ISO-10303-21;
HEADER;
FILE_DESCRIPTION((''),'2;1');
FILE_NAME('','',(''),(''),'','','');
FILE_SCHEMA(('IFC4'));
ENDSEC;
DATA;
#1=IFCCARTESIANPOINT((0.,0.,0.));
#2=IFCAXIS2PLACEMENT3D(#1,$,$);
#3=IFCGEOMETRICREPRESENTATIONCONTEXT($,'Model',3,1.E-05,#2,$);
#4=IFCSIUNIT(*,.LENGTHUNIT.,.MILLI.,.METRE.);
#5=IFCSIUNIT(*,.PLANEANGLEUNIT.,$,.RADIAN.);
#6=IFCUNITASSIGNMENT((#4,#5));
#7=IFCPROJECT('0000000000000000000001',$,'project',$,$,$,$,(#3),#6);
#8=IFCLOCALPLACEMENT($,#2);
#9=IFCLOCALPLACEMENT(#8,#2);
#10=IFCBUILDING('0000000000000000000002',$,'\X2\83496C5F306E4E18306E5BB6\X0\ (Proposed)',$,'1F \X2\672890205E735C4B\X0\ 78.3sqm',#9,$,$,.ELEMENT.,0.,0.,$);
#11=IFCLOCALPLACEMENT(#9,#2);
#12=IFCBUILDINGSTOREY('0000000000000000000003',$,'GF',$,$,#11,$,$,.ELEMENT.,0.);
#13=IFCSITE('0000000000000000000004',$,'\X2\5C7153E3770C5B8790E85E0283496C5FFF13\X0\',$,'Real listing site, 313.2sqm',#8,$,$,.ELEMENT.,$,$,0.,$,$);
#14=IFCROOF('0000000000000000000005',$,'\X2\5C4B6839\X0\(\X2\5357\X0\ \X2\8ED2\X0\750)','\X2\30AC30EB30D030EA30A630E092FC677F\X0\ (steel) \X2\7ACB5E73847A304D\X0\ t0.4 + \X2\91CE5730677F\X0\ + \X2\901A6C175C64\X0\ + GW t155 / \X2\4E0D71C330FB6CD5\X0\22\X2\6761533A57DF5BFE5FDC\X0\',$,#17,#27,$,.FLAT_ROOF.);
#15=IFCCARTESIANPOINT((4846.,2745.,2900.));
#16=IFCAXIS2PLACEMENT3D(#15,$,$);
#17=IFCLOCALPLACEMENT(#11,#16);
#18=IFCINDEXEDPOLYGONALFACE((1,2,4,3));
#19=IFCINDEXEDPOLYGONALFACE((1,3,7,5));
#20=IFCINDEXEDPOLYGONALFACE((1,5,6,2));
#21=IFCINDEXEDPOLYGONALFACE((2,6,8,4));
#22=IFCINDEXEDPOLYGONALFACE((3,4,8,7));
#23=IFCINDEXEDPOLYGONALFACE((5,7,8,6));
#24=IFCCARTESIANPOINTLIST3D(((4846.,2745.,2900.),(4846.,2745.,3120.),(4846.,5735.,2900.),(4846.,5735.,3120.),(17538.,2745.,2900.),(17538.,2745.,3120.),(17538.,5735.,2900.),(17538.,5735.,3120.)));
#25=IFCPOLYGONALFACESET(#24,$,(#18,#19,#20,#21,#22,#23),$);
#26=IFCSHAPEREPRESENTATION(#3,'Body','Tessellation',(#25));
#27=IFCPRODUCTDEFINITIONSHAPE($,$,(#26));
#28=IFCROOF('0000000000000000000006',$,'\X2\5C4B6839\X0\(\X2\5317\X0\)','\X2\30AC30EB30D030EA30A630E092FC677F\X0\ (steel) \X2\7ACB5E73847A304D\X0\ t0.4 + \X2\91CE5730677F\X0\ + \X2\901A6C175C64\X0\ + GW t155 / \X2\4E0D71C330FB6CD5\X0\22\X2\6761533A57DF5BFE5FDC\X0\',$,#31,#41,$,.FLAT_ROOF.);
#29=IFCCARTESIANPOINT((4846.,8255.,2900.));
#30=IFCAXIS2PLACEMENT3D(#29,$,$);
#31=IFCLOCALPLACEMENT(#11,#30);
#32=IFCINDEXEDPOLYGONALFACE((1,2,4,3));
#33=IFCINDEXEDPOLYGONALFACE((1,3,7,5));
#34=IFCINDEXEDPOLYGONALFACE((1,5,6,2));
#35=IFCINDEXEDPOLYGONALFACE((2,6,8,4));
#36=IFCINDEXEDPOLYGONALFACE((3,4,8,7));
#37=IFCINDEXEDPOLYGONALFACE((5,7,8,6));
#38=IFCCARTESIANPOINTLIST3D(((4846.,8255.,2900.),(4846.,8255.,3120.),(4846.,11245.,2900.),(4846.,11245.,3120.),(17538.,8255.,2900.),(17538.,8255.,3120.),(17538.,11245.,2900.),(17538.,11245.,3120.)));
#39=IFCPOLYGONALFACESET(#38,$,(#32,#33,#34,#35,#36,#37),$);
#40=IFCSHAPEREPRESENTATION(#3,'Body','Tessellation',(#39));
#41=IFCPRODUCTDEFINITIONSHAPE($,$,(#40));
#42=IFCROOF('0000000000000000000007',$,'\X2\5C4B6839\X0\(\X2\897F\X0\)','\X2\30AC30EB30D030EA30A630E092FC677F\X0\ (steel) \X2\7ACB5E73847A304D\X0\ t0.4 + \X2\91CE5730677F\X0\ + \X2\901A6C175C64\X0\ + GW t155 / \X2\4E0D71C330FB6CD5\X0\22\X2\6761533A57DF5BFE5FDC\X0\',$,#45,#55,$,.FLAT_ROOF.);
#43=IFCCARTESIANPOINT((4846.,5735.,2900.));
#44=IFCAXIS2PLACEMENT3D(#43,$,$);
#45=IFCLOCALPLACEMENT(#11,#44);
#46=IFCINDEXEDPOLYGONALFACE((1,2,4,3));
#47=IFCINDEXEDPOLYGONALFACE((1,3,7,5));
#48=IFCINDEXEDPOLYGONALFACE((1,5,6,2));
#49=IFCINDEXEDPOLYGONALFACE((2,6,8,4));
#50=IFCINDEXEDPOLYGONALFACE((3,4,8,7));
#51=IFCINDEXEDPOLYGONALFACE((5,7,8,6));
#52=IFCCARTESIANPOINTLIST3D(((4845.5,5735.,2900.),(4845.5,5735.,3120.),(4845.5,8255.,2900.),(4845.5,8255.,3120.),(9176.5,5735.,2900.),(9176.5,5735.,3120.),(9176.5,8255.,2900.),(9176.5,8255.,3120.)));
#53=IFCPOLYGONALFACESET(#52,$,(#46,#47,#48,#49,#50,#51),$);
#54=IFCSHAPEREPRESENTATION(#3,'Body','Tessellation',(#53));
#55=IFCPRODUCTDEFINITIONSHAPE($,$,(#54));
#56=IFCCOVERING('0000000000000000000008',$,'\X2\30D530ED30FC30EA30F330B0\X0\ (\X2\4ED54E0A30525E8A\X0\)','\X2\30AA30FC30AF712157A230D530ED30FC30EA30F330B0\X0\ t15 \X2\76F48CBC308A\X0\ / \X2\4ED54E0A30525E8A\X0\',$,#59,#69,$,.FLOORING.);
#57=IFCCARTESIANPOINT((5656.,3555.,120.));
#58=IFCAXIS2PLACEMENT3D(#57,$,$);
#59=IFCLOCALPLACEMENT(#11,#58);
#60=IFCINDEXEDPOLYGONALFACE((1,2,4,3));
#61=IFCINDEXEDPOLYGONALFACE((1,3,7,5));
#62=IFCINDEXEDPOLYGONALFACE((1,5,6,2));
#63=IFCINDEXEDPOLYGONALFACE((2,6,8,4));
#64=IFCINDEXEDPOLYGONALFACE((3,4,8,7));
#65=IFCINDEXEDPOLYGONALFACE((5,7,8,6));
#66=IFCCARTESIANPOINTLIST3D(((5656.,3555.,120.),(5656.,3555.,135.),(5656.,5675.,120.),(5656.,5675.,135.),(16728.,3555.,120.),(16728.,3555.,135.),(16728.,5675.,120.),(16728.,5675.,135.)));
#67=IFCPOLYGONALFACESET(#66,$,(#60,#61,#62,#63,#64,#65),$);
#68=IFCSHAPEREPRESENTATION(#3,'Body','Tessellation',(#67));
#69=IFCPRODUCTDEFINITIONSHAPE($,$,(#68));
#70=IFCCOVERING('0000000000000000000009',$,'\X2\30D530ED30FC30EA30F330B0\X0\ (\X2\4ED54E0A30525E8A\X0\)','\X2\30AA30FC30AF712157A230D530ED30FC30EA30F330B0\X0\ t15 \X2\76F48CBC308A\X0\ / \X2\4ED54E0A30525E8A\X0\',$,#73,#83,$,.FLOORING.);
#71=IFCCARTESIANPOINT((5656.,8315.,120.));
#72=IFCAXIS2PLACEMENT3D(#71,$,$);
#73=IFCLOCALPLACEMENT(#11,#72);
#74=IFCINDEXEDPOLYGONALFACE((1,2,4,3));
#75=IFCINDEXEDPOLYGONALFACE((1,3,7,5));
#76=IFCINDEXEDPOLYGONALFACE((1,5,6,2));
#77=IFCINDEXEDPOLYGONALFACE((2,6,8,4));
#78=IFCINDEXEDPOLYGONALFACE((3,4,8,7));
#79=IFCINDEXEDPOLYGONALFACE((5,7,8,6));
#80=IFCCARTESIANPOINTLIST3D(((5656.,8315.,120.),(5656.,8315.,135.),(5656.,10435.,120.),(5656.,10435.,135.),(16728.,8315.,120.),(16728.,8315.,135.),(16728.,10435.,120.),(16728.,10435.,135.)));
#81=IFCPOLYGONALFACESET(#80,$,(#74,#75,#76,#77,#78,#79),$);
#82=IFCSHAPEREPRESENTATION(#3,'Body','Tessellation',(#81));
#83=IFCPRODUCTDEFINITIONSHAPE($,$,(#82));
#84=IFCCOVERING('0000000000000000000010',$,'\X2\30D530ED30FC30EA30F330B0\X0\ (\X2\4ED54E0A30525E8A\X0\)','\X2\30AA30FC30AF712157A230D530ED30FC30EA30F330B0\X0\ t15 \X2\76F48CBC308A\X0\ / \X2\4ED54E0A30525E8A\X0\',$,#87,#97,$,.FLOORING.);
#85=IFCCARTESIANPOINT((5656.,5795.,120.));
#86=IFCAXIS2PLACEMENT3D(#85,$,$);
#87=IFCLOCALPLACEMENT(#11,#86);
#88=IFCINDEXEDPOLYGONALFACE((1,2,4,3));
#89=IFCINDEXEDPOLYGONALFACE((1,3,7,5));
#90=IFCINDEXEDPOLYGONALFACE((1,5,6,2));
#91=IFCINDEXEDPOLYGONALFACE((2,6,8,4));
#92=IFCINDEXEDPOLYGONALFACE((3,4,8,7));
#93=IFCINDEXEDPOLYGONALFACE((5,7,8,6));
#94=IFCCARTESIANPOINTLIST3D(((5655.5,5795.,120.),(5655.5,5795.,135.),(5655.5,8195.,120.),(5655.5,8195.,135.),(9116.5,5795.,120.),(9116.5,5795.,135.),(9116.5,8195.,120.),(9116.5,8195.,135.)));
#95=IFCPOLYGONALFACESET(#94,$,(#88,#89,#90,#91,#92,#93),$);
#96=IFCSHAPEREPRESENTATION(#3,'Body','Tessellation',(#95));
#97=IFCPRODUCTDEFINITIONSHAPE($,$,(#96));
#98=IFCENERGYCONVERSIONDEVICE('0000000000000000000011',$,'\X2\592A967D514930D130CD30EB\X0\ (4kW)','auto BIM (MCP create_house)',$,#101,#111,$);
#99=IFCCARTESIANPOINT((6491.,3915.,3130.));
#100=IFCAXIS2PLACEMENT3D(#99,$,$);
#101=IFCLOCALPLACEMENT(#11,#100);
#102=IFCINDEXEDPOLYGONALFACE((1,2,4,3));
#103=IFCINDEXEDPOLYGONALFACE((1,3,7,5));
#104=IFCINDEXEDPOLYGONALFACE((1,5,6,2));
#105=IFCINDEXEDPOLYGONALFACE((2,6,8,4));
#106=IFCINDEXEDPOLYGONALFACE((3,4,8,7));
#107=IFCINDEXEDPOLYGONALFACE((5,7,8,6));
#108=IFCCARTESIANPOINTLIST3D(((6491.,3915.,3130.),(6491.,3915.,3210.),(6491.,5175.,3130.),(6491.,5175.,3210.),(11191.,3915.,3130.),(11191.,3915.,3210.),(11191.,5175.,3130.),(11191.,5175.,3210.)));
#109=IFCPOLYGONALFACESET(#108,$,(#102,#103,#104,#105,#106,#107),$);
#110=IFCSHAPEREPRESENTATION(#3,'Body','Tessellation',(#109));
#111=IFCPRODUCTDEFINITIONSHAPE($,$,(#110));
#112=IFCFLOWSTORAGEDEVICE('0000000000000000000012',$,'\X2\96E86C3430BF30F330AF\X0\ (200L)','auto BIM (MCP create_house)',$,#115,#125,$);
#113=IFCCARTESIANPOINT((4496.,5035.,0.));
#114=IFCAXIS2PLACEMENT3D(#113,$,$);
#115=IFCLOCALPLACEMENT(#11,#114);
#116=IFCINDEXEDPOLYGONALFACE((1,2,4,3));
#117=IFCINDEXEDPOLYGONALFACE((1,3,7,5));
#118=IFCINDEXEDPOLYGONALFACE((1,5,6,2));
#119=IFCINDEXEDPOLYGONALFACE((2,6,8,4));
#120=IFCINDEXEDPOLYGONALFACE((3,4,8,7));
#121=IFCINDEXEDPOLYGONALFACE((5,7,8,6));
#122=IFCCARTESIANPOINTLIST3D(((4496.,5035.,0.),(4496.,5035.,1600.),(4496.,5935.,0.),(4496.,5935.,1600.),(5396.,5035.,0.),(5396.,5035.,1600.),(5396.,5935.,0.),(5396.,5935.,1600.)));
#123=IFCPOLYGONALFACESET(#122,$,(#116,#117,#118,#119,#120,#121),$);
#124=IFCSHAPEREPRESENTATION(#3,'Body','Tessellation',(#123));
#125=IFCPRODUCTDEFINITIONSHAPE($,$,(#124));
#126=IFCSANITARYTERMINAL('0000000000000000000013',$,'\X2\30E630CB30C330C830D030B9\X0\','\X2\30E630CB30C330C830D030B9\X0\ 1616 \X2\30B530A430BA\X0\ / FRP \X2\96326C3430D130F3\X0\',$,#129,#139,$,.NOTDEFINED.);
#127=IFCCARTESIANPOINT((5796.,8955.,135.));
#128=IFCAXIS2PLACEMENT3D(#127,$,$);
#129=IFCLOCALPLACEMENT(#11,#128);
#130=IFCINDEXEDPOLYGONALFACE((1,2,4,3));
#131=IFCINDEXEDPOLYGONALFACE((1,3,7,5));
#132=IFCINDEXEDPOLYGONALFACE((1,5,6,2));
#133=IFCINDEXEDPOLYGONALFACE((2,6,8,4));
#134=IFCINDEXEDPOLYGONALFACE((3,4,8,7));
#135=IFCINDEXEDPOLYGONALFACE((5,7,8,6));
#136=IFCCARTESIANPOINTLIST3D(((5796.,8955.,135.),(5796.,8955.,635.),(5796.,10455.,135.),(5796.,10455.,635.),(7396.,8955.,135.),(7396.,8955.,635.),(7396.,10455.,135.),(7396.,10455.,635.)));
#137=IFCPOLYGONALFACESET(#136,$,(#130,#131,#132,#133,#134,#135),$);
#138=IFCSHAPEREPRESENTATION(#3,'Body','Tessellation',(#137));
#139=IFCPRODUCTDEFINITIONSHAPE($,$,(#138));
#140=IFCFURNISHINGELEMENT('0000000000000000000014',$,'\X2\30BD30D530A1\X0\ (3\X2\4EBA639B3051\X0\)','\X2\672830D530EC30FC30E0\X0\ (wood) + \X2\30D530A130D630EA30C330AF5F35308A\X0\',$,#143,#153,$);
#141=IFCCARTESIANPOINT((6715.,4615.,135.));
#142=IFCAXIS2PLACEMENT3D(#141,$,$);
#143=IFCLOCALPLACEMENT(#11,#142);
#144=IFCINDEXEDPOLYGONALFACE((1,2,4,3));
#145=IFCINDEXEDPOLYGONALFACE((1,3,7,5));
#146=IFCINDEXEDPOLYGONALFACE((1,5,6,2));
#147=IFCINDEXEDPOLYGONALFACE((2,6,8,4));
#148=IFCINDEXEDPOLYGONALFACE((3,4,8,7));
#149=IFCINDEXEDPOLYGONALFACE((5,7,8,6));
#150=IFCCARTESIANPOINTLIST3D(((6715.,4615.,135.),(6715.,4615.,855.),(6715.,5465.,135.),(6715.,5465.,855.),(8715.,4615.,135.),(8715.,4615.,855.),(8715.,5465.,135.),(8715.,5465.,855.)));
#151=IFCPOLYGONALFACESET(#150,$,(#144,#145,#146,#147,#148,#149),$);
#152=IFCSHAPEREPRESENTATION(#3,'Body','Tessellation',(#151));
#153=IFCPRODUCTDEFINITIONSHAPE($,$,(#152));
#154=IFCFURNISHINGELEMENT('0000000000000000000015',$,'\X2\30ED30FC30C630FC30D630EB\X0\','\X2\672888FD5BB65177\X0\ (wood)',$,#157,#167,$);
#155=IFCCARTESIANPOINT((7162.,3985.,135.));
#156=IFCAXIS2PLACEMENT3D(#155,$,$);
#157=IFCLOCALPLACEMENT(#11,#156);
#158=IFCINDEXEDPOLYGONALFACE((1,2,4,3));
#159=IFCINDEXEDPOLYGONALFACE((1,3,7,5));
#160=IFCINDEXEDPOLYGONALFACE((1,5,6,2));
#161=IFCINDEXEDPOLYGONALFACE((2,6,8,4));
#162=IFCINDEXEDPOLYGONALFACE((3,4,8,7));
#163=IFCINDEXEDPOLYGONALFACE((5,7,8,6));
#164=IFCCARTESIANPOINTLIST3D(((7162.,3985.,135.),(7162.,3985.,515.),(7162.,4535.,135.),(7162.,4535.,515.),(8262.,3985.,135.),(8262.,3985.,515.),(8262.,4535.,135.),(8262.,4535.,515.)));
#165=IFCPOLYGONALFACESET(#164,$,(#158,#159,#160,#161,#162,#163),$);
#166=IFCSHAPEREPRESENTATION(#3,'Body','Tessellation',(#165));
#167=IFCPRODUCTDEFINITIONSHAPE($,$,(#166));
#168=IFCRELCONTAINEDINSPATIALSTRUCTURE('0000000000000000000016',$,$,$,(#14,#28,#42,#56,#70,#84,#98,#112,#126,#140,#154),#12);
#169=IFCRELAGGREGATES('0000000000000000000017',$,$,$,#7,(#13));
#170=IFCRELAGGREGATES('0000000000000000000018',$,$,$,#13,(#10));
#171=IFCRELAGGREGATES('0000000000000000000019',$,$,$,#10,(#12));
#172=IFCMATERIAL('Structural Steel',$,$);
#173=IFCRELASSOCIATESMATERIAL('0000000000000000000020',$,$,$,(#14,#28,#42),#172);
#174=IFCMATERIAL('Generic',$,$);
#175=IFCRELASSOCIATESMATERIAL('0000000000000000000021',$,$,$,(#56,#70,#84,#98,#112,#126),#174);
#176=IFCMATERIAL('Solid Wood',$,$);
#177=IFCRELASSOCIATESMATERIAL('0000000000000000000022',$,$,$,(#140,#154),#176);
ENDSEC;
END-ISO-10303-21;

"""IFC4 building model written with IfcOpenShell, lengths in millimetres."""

from ifc_helpers import new_model, si_unit, frame, frame_2d, origin, place, context, project, spatial, rectangle, extrude, material, element, save


model = new_model("IFC4")

# Units and contexts
model_context = context("Model", 3, precision=1e-05, world=origin())
ifc_project = project(units=[si_unit("LENGTHUNIT", "METRE", prefix="MILLI"), si_unit("PLANEANGLEUNIT", "RADIAN")], contexts=[model_context])

# Site, building, storey
site_placement = place(None, origin())
site = spatial("IfcSite", under=ifc_project, at=site_placement, Name="山口県宇部市草江３", ObjectType="Real listing site, 313.2sqm", CompositionType="ELEMENT", RefElevation=0.0)
building_placement = place(site_placement, origin())
building = spatial("IfcBuilding", under=site, at=building_placement, Name="草江の丘の家 (Proposed)", ObjectType="1F 木造平屋 78.3sqm", CompositionType="ELEMENT", ElevationOfRefHeight=0.0, ElevationOfTerrain=0.0)
storey_placement = place(building_placement, origin())
storey = spatial("IfcBuildingStorey", under=building, at=storey_placement, Name="GF", CompositionType="ELEMENT", Elevation=0.0)

# Shared definitions
ifc_material_1 = material(Name="Solid Wood")

# Roofs
ifc_material_2 = material(Name="Structural Steel")
roof_1_placement = place(storey_placement, frame((4846.0, 2745.0, 2900.0)))
element("IfcRoof", 1, at=roof_1_placement, inside=storey, material=ifc_material_2, Name="屋根(南 軒750)", Description="ガルバリウム鋼板 (steel) 立平葺き t0.4 + 野地板 + 通気層 + GW t155 / 不燃・法22条区域対応", PredefinedType="FLAT_ROOF", context=model_context, shape_type="SweptSolid", body=[
    extrude(rectangle(XDim=12692.0, YDim=2990.0, at=frame_2d((6346.0, 1495.0))), frame((4846.0, 2745.0, 2900.0)), (0.0, 0.0, 1.0), 220.0),
])
roof_2_placement = place(storey_placement, frame((4846.0, 8255.0, 2900.0)))
element("IfcRoof", 2, at=roof_2_placement, inside=storey, material=ifc_material_2, Name="屋根(北)", Description="ガルバリウム鋼板 (steel) 立平葺き t0.4 + 野地板 + 通気層 + GW t155 / 不燃・法22条区域対応", PredefinedType="FLAT_ROOF", context=model_context, shape_type="SweptSolid", body=[
    extrude(rectangle(XDim=12692.0, YDim=2990.0, at=frame_2d((6346.0, 1495.0))), frame((4846.0, 8255.0, 2900.0)), (0.0, 0.0, 1.0), 220.0),
])
roof_3_placement = place(storey_placement, frame((4846.0, 5735.0, 2900.0)))
element("IfcRoof", 3, at=roof_3_placement, inside=storey, material=ifc_material_2, Name="屋根(西)", Description="ガルバリウム鋼板 (steel) 立平葺き t0.4 + 野地板 + 通気層 + GW t155 / 不燃・法22条区域対応", PredefinedType="FLAT_ROOF", context=model_context, shape_type="SweptSolid", body=[
    extrude(rectangle(XDim=4331.0, YDim=2520.0, at=frame_2d((2165.0, 1260.0))), frame((4846.0, 5735.0, 2900.0)), (0.0, 0.0, 1.0), 220.0),
])

# Coverings
ifc_material_3 = material(Name="Generic")
covering_1_placement = place(storey_placement, frame((5656.0, 3555.0, 120.0)))
element("IfcCovering", 4, at=covering_1_placement, inside=storey, material=ifc_material_3, Name="フローリング (仕上げ床)", Description="オーク無垢フローリング t15 直貼り / 仕上げ床", PredefinedType="FLOORING", context=model_context, shape_type="SweptSolid", body=[
    extrude(rectangle(XDim=11072.0, YDim=2120.0, at=frame_2d((5536.0, 1060.0))), frame((5656.0, 3555.0, 120.0)), (0.0, 0.0, 1.0), 15.0),
])
covering_2_placement = place(storey_placement, frame((5656.0, 8315.0, 120.0)))
element("IfcCovering", 5, at=covering_2_placement, inside=storey, material=ifc_material_3, Name="フローリング (仕上げ床)", Description="オーク無垢フローリング t15 直貼り / 仕上げ床", PredefinedType="FLOORING", context=model_context, shape_type="SweptSolid", body=[
    extrude(rectangle(XDim=11072.0, YDim=2120.0, at=frame_2d((5536.0, 1060.0))), frame((5656.0, 8315.0, 120.0)), (0.0, 0.0, 1.0), 15.0),
])
covering_3_placement = place(storey_placement, frame((5656.0, 5795.0, 120.0)))
element("IfcCovering", 6, at=covering_3_placement, inside=storey, material=ifc_material_3, Name="フローリング (仕上げ床)", Description="オーク無垢フローリング t15 直貼り / 仕上げ床", PredefinedType="FLOORING", context=model_context, shape_type="SweptSolid", body=[
    extrude(rectangle(XDim=3461.0, YDim=2400.0, at=frame_2d((1730.0, 1200.0))), frame((5656.0, 5795.0, 120.0)), (0.0, 0.0, 1.0), 15.0),
])

# Energy conversion device
energy_conversion_device_placement = place(storey_placement, frame((6491.0, 3915.0, 3130.0)))
element("IfcEnergyConversionDevice", 7, at=energy_conversion_device_placement, inside=storey, material=ifc_material_3, Name="太陽光パネル (4kW)", Description="auto BIM (MCP create_house)", context=model_context, shape_type="SweptSolid", body=[
    extrude(rectangle(XDim=4700.0, YDim=1260.0, at=frame_2d((2350.0, 630.0))), frame((6491.0, 3915.0, 3130.0)), (0.0, 0.0, 1.0), 80.0),
])

# Flow storage device
flow_storage_device_placement = place(storey_placement, frame((4496.0, 5035.0, 0.0)))
element("IfcFlowStorageDevice", 8, at=flow_storage_device_placement, inside=storey, material=ifc_material_3, Name="雨水タンク (200L)", Description="auto BIM (MCP create_house)", context=model_context, shape_type="SweptSolid", body=[
    extrude(rectangle(XDim=900.0, YDim=900.0, at=frame_2d((450.0, 450.0))), frame((4496.0, 5035.0, 0.0)), (0.0, 0.0, 1.0), 1600.0),
])

# Sanitary terminal
sanitary_terminal_placement = place(storey_placement, frame((5796.0, 8955.0, 135.0)))
element("IfcSanitaryTerminal", 9, at=sanitary_terminal_placement, inside=storey, material=ifc_material_3, Name="ユニットバス", Description="ユニットバス 1616 サイズ / FRP 防水パン", PredefinedType="NOTDEFINED", context=model_context, shape_type="SweptSolid", body=[
    extrude(rectangle(XDim=1600.0, YDim=1500.0, at=frame_2d((800.0, 750.0))), frame((5796.0, 8955.0, 135.0)), (0.0, 0.0, 1.0), 500.0),
])

# Furnishing elements
furnishing_1_placement = place(storey_placement, frame((6715.0, 4615.0, 135.0)))
element("IfcFurnishingElement", 10, at=furnishing_1_placement, inside=storey, material=ifc_material_1, Name="ソファ (3人掛け)", Description="木フレーム (wood) + ファブリック張り", context=model_context, shape_type="SweptSolid", body=[
    extrude(rectangle(XDim=2000.0, YDim=850.0, at=frame_2d((1000.0, 425.0))), frame((6715.0, 4615.0, 135.0)), (0.0, 0.0, 1.0), 720.0),
])
furnishing_2_placement = place(storey_placement, frame((7162.0, 3985.0, 135.0)))
element("IfcFurnishingElement", 11, at=furnishing_2_placement, inside=storey, material=ifc_material_1, Name="ローテーブル", Description="木製家具 (wood)", context=model_context, shape_type="SweptSolid", body=[
    extrude(rectangle(XDim=1100.0, YDim=550.0, at=frame_2d((550.0, 275.0))), frame((7162.0, 3985.0, 135.0)), (0.0, 0.0, 1.0), 380.0),
])

save(model, "model.ifc")
